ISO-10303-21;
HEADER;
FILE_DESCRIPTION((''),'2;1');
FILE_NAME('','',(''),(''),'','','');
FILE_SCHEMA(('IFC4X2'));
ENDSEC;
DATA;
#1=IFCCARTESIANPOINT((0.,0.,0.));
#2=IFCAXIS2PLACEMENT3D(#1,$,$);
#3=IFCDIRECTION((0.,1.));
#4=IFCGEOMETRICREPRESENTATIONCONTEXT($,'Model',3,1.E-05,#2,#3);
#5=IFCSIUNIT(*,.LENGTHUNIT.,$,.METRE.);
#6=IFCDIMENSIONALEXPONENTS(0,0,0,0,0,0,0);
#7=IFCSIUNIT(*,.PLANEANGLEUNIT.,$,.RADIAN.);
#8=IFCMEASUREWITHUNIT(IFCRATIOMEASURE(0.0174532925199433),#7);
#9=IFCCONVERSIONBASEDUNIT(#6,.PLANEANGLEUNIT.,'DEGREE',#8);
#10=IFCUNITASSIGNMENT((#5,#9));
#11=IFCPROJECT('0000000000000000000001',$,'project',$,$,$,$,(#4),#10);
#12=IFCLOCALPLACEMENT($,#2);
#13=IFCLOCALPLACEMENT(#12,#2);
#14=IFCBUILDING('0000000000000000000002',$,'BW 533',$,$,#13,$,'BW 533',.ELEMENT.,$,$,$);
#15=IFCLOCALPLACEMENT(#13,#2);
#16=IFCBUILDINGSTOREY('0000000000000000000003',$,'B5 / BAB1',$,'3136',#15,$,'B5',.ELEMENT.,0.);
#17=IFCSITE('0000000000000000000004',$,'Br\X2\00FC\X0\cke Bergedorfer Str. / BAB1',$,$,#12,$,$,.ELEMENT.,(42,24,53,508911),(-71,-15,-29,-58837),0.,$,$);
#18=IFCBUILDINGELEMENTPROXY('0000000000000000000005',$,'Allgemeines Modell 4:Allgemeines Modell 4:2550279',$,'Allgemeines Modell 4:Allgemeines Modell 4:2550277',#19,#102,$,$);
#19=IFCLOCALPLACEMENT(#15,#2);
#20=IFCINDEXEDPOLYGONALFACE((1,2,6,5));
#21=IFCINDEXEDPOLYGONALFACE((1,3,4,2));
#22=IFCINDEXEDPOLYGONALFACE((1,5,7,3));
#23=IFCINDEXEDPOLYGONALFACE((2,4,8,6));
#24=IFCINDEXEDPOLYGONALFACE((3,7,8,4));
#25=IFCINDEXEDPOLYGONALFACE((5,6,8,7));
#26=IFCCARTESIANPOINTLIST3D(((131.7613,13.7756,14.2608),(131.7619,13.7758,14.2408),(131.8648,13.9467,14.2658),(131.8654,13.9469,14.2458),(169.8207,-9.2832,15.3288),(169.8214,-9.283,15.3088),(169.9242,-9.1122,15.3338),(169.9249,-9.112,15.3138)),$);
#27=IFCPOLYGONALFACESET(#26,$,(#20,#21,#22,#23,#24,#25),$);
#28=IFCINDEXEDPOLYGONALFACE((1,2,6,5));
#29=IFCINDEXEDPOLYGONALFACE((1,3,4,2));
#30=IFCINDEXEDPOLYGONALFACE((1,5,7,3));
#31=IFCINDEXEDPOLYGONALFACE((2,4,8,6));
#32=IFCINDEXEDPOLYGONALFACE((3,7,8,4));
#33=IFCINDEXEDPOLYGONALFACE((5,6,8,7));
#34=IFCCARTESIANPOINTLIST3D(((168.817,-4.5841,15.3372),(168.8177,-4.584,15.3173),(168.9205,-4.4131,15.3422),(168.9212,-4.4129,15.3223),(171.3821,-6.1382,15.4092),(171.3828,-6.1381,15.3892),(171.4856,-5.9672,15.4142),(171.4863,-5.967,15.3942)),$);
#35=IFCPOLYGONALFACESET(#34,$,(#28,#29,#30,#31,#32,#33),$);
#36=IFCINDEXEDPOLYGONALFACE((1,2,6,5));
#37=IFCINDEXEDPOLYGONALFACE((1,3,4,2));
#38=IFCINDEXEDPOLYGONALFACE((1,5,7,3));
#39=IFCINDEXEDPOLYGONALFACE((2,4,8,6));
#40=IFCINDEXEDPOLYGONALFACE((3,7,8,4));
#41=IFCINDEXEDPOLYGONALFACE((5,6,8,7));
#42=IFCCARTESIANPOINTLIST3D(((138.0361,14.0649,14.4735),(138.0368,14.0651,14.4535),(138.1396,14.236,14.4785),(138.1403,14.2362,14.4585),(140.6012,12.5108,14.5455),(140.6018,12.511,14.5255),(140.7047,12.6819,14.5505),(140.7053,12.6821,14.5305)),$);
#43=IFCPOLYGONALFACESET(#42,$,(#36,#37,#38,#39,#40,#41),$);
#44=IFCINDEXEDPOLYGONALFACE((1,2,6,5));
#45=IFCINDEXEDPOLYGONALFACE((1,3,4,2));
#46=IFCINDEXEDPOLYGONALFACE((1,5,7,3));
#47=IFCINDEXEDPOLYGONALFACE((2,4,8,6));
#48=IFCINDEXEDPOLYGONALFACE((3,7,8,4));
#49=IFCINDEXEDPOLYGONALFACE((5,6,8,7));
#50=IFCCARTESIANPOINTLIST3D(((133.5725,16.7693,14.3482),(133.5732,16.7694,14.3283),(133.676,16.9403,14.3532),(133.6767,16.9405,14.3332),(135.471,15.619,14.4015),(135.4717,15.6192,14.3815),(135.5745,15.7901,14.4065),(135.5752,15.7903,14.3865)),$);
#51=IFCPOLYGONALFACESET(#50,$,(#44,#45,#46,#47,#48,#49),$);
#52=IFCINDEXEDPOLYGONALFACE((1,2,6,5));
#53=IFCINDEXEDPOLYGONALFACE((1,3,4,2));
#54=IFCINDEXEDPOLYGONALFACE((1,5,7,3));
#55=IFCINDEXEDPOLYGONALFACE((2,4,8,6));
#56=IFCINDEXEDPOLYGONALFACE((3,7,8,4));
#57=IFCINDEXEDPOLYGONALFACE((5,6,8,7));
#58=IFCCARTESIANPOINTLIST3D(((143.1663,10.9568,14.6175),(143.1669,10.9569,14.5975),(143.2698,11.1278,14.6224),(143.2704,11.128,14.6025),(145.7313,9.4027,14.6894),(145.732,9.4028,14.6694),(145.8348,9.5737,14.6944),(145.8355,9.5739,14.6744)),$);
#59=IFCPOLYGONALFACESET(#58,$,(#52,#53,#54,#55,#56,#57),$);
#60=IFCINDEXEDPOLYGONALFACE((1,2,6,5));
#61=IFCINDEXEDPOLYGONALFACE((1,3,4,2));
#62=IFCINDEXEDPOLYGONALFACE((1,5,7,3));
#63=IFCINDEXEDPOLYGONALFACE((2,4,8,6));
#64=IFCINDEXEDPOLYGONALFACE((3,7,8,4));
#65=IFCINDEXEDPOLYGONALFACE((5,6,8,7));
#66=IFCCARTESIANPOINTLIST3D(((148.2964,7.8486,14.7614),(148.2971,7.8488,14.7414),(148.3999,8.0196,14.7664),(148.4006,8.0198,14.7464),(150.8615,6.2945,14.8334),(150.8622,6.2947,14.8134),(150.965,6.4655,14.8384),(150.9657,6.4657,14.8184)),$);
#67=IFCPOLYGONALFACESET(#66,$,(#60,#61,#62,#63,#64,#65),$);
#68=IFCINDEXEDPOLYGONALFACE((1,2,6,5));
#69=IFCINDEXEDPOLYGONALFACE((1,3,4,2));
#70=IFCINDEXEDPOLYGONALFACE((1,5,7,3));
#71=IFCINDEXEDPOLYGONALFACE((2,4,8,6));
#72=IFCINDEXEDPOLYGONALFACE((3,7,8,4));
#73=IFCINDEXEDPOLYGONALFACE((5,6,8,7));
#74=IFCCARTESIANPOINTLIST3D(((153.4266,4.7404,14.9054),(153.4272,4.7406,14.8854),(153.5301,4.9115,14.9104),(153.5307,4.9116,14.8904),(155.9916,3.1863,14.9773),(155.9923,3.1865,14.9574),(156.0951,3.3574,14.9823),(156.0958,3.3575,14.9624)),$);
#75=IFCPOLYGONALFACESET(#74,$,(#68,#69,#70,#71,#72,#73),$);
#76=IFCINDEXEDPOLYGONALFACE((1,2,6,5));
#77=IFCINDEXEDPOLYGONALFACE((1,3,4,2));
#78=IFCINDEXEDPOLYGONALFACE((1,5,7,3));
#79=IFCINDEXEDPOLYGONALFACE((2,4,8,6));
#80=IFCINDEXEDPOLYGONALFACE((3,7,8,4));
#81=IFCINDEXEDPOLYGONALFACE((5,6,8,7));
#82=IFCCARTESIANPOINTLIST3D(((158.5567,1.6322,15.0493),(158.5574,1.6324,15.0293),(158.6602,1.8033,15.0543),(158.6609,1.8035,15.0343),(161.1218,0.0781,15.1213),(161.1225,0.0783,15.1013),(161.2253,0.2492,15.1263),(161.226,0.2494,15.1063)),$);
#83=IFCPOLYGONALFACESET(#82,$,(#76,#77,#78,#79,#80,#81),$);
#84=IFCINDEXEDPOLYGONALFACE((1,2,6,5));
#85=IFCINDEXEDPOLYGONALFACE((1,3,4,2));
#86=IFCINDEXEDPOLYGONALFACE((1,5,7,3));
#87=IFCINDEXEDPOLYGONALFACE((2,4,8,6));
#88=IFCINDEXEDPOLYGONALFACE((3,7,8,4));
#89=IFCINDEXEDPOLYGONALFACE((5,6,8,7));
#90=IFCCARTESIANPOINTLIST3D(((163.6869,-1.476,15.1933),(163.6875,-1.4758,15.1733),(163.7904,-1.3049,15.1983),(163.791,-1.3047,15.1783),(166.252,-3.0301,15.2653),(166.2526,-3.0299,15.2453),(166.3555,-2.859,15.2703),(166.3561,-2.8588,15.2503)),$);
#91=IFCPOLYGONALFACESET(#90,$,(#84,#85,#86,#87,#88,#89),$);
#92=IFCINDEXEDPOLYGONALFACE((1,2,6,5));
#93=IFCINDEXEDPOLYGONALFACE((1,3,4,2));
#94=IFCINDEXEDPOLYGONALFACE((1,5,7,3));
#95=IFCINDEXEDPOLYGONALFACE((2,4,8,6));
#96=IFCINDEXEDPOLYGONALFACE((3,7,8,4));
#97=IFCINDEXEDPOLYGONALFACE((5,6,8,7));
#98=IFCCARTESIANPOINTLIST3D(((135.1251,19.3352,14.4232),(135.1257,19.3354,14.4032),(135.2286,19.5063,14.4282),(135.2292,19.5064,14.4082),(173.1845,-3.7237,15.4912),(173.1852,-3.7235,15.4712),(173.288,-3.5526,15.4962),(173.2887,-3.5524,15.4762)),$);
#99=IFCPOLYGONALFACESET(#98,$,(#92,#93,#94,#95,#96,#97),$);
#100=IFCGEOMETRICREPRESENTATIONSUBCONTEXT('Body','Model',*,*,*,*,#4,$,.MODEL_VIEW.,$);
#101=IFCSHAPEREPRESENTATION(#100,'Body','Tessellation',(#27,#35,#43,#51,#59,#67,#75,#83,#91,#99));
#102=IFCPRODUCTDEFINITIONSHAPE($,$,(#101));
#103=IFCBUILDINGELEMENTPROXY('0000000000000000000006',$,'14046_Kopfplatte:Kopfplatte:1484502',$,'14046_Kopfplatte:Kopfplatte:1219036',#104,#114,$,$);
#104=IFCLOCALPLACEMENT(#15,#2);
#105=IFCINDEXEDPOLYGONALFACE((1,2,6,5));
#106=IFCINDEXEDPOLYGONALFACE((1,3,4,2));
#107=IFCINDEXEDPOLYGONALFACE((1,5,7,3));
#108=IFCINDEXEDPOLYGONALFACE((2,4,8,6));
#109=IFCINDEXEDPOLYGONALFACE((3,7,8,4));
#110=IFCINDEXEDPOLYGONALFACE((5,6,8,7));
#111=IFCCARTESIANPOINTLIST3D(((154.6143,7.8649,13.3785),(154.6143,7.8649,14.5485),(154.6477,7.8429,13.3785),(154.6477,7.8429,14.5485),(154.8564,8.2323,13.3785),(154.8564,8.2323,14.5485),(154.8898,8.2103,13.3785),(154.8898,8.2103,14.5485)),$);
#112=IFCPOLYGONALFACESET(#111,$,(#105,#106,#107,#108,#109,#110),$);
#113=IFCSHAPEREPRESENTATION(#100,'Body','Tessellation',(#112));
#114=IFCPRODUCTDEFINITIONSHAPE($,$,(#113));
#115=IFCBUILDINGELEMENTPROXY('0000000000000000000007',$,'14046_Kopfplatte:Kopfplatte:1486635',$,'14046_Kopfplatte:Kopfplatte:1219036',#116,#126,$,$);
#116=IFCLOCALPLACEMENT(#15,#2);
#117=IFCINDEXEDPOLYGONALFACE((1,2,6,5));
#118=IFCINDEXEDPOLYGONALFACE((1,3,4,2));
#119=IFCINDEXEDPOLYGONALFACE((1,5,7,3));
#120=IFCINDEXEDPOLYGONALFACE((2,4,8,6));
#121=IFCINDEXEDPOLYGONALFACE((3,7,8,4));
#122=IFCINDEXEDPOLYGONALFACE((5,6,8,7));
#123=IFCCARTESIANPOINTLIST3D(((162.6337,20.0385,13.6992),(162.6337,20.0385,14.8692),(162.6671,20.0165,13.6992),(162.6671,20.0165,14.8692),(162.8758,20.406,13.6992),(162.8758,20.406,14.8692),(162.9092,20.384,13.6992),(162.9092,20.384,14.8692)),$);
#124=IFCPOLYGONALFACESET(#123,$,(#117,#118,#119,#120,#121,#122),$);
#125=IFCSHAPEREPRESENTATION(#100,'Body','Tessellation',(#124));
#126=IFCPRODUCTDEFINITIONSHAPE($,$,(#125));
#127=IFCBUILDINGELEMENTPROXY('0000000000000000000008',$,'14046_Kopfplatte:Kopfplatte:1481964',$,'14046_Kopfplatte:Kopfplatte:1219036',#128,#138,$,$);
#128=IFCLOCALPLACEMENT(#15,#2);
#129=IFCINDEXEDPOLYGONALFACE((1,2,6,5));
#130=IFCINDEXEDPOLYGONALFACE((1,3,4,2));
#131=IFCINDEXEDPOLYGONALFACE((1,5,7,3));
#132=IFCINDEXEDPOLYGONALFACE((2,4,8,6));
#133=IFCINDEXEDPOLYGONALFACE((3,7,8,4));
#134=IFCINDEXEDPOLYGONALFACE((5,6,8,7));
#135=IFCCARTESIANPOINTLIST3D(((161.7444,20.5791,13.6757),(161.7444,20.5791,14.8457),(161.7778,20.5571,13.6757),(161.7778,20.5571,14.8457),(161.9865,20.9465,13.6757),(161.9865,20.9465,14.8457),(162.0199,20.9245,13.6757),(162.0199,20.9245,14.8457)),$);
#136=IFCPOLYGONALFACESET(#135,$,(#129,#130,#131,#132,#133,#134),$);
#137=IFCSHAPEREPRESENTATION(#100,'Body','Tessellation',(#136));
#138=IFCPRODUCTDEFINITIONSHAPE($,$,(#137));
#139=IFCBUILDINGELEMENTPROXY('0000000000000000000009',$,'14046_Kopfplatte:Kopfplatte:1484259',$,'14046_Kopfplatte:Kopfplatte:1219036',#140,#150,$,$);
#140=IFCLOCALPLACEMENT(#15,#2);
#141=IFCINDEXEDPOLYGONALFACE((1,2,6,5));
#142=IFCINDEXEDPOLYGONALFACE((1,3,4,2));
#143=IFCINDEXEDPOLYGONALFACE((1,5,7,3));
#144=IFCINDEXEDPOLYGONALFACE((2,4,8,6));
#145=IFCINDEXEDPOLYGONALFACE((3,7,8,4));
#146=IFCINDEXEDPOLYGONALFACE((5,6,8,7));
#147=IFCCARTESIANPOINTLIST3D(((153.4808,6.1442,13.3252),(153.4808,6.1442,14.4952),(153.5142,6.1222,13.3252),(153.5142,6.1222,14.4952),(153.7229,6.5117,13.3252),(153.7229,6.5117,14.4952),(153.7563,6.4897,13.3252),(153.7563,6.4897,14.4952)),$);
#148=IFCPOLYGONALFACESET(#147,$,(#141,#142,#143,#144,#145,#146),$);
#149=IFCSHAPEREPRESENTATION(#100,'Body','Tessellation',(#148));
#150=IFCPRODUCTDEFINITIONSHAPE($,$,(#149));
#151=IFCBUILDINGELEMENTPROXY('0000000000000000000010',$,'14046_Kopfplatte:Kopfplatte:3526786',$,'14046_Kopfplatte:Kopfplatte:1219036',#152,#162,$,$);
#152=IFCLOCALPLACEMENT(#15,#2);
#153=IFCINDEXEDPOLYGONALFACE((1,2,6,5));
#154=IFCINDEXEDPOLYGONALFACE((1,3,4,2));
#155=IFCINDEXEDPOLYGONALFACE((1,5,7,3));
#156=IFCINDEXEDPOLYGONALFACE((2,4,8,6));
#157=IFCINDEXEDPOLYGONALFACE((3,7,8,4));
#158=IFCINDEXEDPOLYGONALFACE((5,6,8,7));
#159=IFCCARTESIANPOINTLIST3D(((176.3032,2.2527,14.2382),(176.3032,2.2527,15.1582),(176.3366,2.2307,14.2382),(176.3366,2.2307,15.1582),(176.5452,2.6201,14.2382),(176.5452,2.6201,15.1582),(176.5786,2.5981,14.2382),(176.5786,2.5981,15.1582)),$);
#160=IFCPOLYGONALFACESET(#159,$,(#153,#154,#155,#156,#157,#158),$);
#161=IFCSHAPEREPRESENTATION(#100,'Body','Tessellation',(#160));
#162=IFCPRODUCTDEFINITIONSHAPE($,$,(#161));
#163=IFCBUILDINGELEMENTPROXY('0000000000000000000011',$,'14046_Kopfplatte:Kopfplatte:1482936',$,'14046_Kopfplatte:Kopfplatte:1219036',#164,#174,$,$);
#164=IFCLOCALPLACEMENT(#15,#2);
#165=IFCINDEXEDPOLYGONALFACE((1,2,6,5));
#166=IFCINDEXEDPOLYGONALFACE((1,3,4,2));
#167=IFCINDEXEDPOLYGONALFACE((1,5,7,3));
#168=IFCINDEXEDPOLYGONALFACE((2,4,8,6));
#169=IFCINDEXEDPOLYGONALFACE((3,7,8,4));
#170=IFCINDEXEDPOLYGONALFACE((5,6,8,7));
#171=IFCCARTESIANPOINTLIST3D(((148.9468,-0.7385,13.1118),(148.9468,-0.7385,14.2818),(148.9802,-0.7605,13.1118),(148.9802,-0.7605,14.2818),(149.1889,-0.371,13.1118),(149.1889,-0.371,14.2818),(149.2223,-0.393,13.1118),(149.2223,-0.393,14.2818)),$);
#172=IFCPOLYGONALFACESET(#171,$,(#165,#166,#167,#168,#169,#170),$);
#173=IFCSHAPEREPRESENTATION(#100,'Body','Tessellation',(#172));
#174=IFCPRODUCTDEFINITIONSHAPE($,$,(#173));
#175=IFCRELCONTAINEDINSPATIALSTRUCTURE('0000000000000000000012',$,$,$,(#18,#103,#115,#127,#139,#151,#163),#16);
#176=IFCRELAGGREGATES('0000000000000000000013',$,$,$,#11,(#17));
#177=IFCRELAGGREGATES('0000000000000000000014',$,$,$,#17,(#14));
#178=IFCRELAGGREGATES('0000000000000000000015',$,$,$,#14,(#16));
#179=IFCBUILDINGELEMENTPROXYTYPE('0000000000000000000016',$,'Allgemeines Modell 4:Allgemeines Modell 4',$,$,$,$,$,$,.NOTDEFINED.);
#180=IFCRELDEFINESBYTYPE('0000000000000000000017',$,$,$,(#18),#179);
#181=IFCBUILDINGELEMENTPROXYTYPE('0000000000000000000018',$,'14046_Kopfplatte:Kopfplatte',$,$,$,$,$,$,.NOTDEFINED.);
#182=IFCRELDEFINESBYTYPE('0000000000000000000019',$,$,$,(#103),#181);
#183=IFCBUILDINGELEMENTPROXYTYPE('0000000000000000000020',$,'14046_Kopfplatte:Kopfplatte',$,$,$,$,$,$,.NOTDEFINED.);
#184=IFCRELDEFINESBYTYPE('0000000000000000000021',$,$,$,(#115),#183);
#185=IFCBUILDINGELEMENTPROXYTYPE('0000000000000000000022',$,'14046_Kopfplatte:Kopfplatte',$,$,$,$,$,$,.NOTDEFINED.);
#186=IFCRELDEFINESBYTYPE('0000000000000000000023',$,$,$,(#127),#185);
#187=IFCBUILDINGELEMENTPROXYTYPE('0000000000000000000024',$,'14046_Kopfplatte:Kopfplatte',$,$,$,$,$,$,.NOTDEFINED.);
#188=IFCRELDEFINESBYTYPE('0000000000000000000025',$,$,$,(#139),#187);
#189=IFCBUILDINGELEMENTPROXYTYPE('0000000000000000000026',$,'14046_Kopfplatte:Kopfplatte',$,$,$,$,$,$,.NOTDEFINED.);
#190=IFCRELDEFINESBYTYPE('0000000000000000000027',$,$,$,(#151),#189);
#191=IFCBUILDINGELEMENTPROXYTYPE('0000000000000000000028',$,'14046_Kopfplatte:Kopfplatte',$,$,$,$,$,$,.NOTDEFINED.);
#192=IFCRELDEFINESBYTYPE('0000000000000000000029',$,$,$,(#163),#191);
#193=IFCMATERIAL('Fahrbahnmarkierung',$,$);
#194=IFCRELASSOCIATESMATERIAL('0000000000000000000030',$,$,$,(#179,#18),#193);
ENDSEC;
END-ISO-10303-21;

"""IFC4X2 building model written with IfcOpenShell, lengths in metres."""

from ifc_helpers import new_model, entity, si_unit, converted_unit, direction, frame, frame_2d, origin, origin_2d_with_axis, place, context, subcontext, project, spatial, rectangle, extrude, source, transform, mapped, material, type_object, type_shapes, element, save


model = new_model("IFC4X2")

# Units and contexts
model_context = context("Model", 3, precision=1e-05, world=origin(), true_north=direction((0.0, 1.0)))
body_context = subcontext(model_context, "Body", "Model", "MODEL_VIEW")
ifc_project = project(units=[si_unit("LENGTHUNIT", "METRE"), converted_unit("PLANEANGLEUNIT", "DEGREE", entity("IfcRatioMeasure", 0.0174532925199433), si_unit("PLANEANGLEUNIT", "RADIAN"), dimensions=[0, 0, 0, 0, 0, 0, 0])], contexts=[model_context])

# Site, building, storey
site_placement = place(None, origin())
site = spatial("IfcSite", under=ifc_project, at=site_placement, Name="Brücke Bergedorfer Str. / BAB1", CompositionType="ELEMENT", RefLatitude=(42, 24, 53, 508911), RefLongitude=(-71, -15, -29, -58837), RefElevation=0.0)
building_placement = place(site_placement, origin())
building = spatial("IfcBuilding", under=site, at=building_placement, Name="BW 533", LongName="BW 533", CompositionType="ELEMENT")
storey_placement = place(building_placement, origin())
storey = spatial("IfcBuildingStorey", under=building, at=storey_placement, Name="B5 / BAB1", ObjectType="3136", LongName="B5", CompositionType="ELEMENT", Elevation=0.0)

# Building element proxies
ifc_material_1 = material(Name="Fahrbahnmarkierung")
building_element_proxy_type_1 = type_object("IfcBuildingElementProxyType", Name="Allgemeines Modell 4:Allgemeines Modell 4", PredefinedType="NOTDEFINED", material=ifc_material_1)
shared_shape_1 = source(origin(), body_context, "Body", "SweptSolid", [
    extrude(rectangle(XDim=0.02, YDim=0.2, at=frame_2d((0.0, 0.0), x_axis=(0.0, 1.0))), frame((131.8134, 13.8613, 14.2533), z_axis=(0.855026, -0.51803, 0.023993), x_axis=(0.517505, 0.855316, 0.024978)), (0.0, 0.0, 1.0), 44.5126),
    extrude(rectangle(XDim=0.02, YDim=0.2, at=frame_2d((0.0, 0.0), x_axis=(1.0, 0.0))), frame((168.8691, -4.4985, 15.3297), z_axis=(0.855026, -0.51803, 0.023993), x_axis=(-0.033461, -0.00894, 0.9994)), (0.0, 0.0, 1.0), 3.0),
    extrude(rectangle(XDim=0.02, YDim=0.2, at=frame_2d((0.0, 0.0), x_axis=(1.0, 0.0))), frame((138.0882, 14.1506, 14.466), z_axis=(0.855026, -0.51803, 0.023993), x_axis=(-0.033461, -0.00894, 0.9994)), (0.0, 0.0, 1.0), 3.0),
    extrude(rectangle(XDim=0.02, YDim=0.2, at=frame_2d((0.0, 0.0), x_axis=(0.0, 1.0))), frame((133.6246, 16.8549, 14.3407), z_axis=(0.855026, -0.51803, 0.023993), x_axis=(0.517505, 0.855316, 0.024978)), (0.0, 0.0, 1.0), 2.2204),
    extrude(rectangle(XDim=0.02, YDim=0.2, at=frame_2d((0.0, 0.0), x_axis=(1.0, 0.0))), frame((143.2183, 11.0424, 14.61), z_axis=(0.855026, -0.51803, 0.023993), x_axis=(-0.033461, -0.00894, 0.9994)), (0.0, 0.0, 1.0), 3.0),
    extrude(rectangle(XDim=0.02, YDim=0.2, at=frame_2d((0.0, 0.0), x_axis=(1.0, 0.0))), frame((148.3485, 7.9342, 14.7539), z_axis=(0.855026, -0.51803, 0.023993), x_axis=(-0.033461, -0.00894, 0.9994)), (0.0, 0.0, 1.0), 3.0),
    extrude(rectangle(XDim=0.02, YDim=0.2, at=frame_2d((0.0, 0.0), x_axis=(1.0, 0.0))), frame((153.4786, 4.826, 14.8979), z_axis=(0.855026, -0.51803, 0.023993), x_axis=(-0.033461, -0.00894, 0.9994)), (0.0, 0.0, 1.0), 3.0),
    extrude(rectangle(XDim=0.02, YDim=0.2, at=frame_2d((0.0, 0.0), x_axis=(1.0, 0.0))), frame((158.6088, 1.7178, 15.0418), z_axis=(0.855026, -0.51803, 0.023993), x_axis=(-0.033461, -0.00894, 0.9994)), (0.0, 0.0, 1.0), 3.0),
    extrude(rectangle(XDim=0.02, YDim=0.2, at=frame_2d((0.0, 0.0), x_axis=(1.0, 0.0))), frame((163.739, -1.3903, 15.1858), z_axis=(0.855026, -0.51803, 0.023993), x_axis=(-0.033461, -0.00894, 0.9994)), (0.0, 0.0, 1.0), 3.0),
    extrude(rectangle(XDim=0.02, YDim=0.2, at=frame_2d((0.0, 0.0), x_axis=(0.0, 1.0))), frame((135.1771, 19.4208, 14.4157), z_axis=(0.855026, -0.51803, 0.023993), x_axis=(0.517505, 0.855316, 0.024978)), (0.0, 0.0, 1.0), 44.5126),
])
type_shapes(building_element_proxy_type_1, [shared_shape_1])
proxy_1_placement = place(storey_placement, origin())
element("IfcBuildingElementProxy", 1, at=proxy_1_placement, inside=storey, type_object=building_element_proxy_type_1, material=ifc_material_1, Name="Allgemeines Modell 4:Allgemeines Modell 4:2550279", ObjectType="Allgemeines Modell 4:Allgemeines Modell 4:2550277", context=body_context, shape_type="MappedRepresentation", body=[
    mapped(shared_shape_1, transform((0.0, 0.0, 0.0), scale=1.0)),
])
building_element_proxy_type_2 = type_object("IfcBuildingElementProxyType", Name="14046_Kopfplatte:Kopfplatte", PredefinedType="NOTDEFINED")
shared_shape_2 = source(origin(), body_context, "Body", "SweptSolid", [
    extrude(rectangle(XDim=0.04, YDim=0.44, at=frame_2d((0.0, 0.0), x_axis=(1.0, 0.0))), frame((154.7521, 8.0376, 13.3785), z_axis=(0.0, 0.0, 1.0), x_axis=(-0.835088, 0.550116, 0.0)), (0.0, 0.0, 1.0), 1.17),
])
type_shapes(building_element_proxy_type_2, [shared_shape_2])
proxy_2_placement = place(storey_placement, origin())
element("IfcBuildingElementProxy", 2, at=proxy_2_placement, inside=storey, type_object=building_element_proxy_type_2, Name="14046_Kopfplatte:Kopfplatte:1484502", ObjectType="14046_Kopfplatte:Kopfplatte:1219036", context=body_context, shape_type="MappedRepresentation", body=[
    mapped(shared_shape_2, transform((0.0, 0.0, 0.0), scale=1.0)),
])
building_element_proxy_type_3 = type_object("IfcBuildingElementProxyType", Name="14046_Kopfplatte:Kopfplatte", PredefinedType="NOTDEFINED")
shared_shape_3 = source(origin(), body_context, "Body", "SweptSolid", [
    extrude(rectangle(XDim=0.04, YDim=0.44, at=frame_2d((0.0, 0.0), x_axis=(1.0, 0.0))), frame((162.7715, 20.2112, 13.6992), z_axis=(0.0, 0.0, 1.0), x_axis=(-0.835088, 0.550116, 0.0)), (0.0, 0.0, 1.0), 1.17),
])
type_shapes(building_element_proxy_type_3, [shared_shape_3])
proxy_3_placement = place(storey_placement, origin())
element("IfcBuildingElementProxy", 3, at=proxy_3_placement, inside=storey, type_object=building_element_proxy_type_3, Name="14046_Kopfplatte:Kopfplatte:1486635", ObjectType="14046_Kopfplatte:Kopfplatte:1219036", context=body_context, shape_type="MappedRepresentation", body=[
    mapped(shared_shape_3, transform((0.0, 0.0, 0.0), scale=1.0)),
])
building_element_proxy_type_4 = type_object("IfcBuildingElementProxyType", Name="14046_Kopfplatte:Kopfplatte", PredefinedType="NOTDEFINED")
shared_shape_4 = source(origin(), body_context, "Body", "SweptSolid", [
    extrude(rectangle(XDim=0.04, YDim=0.44, at=frame_2d((0.0, 0.0), x_axis=(1.0, 0.0))), frame((161.8822, 20.7518, 13.6757), z_axis=(0.0, 0.0, 1.0), x_axis=(0.835088, -0.550116, 0.0)), (0.0, 0.0, 1.0), 1.17),
])
type_shapes(building_element_proxy_type_4, [shared_shape_4])
proxy_4_placement = place(storey_placement, origin())
element("IfcBuildingElementProxy", 4, at=proxy_4_placement, inside=storey, type_object=building_element_proxy_type_4, Name="14046_Kopfplatte:Kopfplatte:1481964", ObjectType="14046_Kopfplatte:Kopfplatte:1219036", context=body_context, shape_type="MappedRepresentation", body=[
    mapped(shared_shape_4, transform((0.0, 0.0, 0.0), scale=1.0)),
])
building_element_proxy_type_5 = type_object("IfcBuildingElementProxyType", Name="14046_Kopfplatte:Kopfplatte", PredefinedType="NOTDEFINED")
shared_shape_5 = source(origin(), body_context, "Body", "SweptSolid", [
    extrude(rectangle(XDim=0.04, YDim=0.44, at=origin_2d_with_axis()), frame((153.6186, 6.3169, 13.3252), z_axis=(0.0, 0.0, 1.0), x_axis=(-0.835088, 0.550116, 0.0)), (0.0, 0.0, 1.0), 1.17),
])
type_shapes(building_element_proxy_type_5, [shared_shape_5])
proxy_5_placement = place(storey_placement, origin())
element("IfcBuildingElementProxy", 5, at=proxy_5_placement, inside=storey, type_object=building_element_proxy_type_5, Name="14046_Kopfplatte:Kopfplatte:1484259", ObjectType="14046_Kopfplatte:Kopfplatte:1219036", context=body_context, shape_type="MappedRepresentation", body=[
    mapped(shared_shape_5, transform((0.0, 0.0, 0.0), scale=1.0)),
])
building_element_proxy_type_6 = type_object("IfcBuildingElementProxyType", Name="14046_Kopfplatte:Kopfplatte", PredefinedType="NOTDEFINED")
shared_shape_6 = source(origin(), body_context, "Body", "SweptSolid", [
    extrude(rectangle(XDim=0.04, YDim=0.44, at=frame_2d((0.0, 0.0), x_axis=(1.0, 0.0))), frame((176.4409, 2.4254, 14.2382), z_axis=(0.0, 0.0, 1.0), x_axis=(0.835088, -0.550116, 0.0)), (0.0, 0.0, 1.0), 0.92),
])
type_shapes(building_element_proxy_type_6, [shared_shape_6])
proxy_6_placement = place(storey_placement, origin())
element("IfcBuildingElementProxy", 6, at=proxy_6_placement, inside=storey, type_object=building_element_proxy_type_6, Name="14046_Kopfplatte:Kopfplatte:3526786", ObjectType="14046_Kopfplatte:Kopfplatte:1219036", context=body_context, shape_type="MappedRepresentation", body=[
    mapped(shared_shape_6, transform((0.0, 0.0, 0.0), scale=1.0)),
])
building_element_proxy_type_7 = type_object("IfcBuildingElementProxyType", Name="14046_Kopfplatte:Kopfplatte", PredefinedType="NOTDEFINED")
shared_shape_7 = source(origin(), body_context, "Body", "SweptSolid", [
    extrude(rectangle(XDim=0.04, YDim=0.44, at=frame_2d((0.0, 0.0), x_axis=(1.0, 0.0))), frame((149.0846, -0.5658, 13.1118), z_axis=(0.0, 0.0, 1.0), x_axis=(-0.835088, 0.550116, 0.0)), (0.0, 0.0, 1.0), 1.17),
])
type_shapes(building_element_proxy_type_7, [shared_shape_7])
proxy_7_placement = place(storey_placement, origin())
element("IfcBuildingElementProxy", 7, at=proxy_7_placement, inside=storey, type_object=building_element_proxy_type_7, Name="14046_Kopfplatte:Kopfplatte:1482936", ObjectType="14046_Kopfplatte:Kopfplatte:1219036", context=body_context, shape_type="MappedRepresentation", body=[
    mapped(shared_shape_7, transform((0.0, 0.0, 0.0), scale=1.0)),
])

save(model, "model.ifc")
